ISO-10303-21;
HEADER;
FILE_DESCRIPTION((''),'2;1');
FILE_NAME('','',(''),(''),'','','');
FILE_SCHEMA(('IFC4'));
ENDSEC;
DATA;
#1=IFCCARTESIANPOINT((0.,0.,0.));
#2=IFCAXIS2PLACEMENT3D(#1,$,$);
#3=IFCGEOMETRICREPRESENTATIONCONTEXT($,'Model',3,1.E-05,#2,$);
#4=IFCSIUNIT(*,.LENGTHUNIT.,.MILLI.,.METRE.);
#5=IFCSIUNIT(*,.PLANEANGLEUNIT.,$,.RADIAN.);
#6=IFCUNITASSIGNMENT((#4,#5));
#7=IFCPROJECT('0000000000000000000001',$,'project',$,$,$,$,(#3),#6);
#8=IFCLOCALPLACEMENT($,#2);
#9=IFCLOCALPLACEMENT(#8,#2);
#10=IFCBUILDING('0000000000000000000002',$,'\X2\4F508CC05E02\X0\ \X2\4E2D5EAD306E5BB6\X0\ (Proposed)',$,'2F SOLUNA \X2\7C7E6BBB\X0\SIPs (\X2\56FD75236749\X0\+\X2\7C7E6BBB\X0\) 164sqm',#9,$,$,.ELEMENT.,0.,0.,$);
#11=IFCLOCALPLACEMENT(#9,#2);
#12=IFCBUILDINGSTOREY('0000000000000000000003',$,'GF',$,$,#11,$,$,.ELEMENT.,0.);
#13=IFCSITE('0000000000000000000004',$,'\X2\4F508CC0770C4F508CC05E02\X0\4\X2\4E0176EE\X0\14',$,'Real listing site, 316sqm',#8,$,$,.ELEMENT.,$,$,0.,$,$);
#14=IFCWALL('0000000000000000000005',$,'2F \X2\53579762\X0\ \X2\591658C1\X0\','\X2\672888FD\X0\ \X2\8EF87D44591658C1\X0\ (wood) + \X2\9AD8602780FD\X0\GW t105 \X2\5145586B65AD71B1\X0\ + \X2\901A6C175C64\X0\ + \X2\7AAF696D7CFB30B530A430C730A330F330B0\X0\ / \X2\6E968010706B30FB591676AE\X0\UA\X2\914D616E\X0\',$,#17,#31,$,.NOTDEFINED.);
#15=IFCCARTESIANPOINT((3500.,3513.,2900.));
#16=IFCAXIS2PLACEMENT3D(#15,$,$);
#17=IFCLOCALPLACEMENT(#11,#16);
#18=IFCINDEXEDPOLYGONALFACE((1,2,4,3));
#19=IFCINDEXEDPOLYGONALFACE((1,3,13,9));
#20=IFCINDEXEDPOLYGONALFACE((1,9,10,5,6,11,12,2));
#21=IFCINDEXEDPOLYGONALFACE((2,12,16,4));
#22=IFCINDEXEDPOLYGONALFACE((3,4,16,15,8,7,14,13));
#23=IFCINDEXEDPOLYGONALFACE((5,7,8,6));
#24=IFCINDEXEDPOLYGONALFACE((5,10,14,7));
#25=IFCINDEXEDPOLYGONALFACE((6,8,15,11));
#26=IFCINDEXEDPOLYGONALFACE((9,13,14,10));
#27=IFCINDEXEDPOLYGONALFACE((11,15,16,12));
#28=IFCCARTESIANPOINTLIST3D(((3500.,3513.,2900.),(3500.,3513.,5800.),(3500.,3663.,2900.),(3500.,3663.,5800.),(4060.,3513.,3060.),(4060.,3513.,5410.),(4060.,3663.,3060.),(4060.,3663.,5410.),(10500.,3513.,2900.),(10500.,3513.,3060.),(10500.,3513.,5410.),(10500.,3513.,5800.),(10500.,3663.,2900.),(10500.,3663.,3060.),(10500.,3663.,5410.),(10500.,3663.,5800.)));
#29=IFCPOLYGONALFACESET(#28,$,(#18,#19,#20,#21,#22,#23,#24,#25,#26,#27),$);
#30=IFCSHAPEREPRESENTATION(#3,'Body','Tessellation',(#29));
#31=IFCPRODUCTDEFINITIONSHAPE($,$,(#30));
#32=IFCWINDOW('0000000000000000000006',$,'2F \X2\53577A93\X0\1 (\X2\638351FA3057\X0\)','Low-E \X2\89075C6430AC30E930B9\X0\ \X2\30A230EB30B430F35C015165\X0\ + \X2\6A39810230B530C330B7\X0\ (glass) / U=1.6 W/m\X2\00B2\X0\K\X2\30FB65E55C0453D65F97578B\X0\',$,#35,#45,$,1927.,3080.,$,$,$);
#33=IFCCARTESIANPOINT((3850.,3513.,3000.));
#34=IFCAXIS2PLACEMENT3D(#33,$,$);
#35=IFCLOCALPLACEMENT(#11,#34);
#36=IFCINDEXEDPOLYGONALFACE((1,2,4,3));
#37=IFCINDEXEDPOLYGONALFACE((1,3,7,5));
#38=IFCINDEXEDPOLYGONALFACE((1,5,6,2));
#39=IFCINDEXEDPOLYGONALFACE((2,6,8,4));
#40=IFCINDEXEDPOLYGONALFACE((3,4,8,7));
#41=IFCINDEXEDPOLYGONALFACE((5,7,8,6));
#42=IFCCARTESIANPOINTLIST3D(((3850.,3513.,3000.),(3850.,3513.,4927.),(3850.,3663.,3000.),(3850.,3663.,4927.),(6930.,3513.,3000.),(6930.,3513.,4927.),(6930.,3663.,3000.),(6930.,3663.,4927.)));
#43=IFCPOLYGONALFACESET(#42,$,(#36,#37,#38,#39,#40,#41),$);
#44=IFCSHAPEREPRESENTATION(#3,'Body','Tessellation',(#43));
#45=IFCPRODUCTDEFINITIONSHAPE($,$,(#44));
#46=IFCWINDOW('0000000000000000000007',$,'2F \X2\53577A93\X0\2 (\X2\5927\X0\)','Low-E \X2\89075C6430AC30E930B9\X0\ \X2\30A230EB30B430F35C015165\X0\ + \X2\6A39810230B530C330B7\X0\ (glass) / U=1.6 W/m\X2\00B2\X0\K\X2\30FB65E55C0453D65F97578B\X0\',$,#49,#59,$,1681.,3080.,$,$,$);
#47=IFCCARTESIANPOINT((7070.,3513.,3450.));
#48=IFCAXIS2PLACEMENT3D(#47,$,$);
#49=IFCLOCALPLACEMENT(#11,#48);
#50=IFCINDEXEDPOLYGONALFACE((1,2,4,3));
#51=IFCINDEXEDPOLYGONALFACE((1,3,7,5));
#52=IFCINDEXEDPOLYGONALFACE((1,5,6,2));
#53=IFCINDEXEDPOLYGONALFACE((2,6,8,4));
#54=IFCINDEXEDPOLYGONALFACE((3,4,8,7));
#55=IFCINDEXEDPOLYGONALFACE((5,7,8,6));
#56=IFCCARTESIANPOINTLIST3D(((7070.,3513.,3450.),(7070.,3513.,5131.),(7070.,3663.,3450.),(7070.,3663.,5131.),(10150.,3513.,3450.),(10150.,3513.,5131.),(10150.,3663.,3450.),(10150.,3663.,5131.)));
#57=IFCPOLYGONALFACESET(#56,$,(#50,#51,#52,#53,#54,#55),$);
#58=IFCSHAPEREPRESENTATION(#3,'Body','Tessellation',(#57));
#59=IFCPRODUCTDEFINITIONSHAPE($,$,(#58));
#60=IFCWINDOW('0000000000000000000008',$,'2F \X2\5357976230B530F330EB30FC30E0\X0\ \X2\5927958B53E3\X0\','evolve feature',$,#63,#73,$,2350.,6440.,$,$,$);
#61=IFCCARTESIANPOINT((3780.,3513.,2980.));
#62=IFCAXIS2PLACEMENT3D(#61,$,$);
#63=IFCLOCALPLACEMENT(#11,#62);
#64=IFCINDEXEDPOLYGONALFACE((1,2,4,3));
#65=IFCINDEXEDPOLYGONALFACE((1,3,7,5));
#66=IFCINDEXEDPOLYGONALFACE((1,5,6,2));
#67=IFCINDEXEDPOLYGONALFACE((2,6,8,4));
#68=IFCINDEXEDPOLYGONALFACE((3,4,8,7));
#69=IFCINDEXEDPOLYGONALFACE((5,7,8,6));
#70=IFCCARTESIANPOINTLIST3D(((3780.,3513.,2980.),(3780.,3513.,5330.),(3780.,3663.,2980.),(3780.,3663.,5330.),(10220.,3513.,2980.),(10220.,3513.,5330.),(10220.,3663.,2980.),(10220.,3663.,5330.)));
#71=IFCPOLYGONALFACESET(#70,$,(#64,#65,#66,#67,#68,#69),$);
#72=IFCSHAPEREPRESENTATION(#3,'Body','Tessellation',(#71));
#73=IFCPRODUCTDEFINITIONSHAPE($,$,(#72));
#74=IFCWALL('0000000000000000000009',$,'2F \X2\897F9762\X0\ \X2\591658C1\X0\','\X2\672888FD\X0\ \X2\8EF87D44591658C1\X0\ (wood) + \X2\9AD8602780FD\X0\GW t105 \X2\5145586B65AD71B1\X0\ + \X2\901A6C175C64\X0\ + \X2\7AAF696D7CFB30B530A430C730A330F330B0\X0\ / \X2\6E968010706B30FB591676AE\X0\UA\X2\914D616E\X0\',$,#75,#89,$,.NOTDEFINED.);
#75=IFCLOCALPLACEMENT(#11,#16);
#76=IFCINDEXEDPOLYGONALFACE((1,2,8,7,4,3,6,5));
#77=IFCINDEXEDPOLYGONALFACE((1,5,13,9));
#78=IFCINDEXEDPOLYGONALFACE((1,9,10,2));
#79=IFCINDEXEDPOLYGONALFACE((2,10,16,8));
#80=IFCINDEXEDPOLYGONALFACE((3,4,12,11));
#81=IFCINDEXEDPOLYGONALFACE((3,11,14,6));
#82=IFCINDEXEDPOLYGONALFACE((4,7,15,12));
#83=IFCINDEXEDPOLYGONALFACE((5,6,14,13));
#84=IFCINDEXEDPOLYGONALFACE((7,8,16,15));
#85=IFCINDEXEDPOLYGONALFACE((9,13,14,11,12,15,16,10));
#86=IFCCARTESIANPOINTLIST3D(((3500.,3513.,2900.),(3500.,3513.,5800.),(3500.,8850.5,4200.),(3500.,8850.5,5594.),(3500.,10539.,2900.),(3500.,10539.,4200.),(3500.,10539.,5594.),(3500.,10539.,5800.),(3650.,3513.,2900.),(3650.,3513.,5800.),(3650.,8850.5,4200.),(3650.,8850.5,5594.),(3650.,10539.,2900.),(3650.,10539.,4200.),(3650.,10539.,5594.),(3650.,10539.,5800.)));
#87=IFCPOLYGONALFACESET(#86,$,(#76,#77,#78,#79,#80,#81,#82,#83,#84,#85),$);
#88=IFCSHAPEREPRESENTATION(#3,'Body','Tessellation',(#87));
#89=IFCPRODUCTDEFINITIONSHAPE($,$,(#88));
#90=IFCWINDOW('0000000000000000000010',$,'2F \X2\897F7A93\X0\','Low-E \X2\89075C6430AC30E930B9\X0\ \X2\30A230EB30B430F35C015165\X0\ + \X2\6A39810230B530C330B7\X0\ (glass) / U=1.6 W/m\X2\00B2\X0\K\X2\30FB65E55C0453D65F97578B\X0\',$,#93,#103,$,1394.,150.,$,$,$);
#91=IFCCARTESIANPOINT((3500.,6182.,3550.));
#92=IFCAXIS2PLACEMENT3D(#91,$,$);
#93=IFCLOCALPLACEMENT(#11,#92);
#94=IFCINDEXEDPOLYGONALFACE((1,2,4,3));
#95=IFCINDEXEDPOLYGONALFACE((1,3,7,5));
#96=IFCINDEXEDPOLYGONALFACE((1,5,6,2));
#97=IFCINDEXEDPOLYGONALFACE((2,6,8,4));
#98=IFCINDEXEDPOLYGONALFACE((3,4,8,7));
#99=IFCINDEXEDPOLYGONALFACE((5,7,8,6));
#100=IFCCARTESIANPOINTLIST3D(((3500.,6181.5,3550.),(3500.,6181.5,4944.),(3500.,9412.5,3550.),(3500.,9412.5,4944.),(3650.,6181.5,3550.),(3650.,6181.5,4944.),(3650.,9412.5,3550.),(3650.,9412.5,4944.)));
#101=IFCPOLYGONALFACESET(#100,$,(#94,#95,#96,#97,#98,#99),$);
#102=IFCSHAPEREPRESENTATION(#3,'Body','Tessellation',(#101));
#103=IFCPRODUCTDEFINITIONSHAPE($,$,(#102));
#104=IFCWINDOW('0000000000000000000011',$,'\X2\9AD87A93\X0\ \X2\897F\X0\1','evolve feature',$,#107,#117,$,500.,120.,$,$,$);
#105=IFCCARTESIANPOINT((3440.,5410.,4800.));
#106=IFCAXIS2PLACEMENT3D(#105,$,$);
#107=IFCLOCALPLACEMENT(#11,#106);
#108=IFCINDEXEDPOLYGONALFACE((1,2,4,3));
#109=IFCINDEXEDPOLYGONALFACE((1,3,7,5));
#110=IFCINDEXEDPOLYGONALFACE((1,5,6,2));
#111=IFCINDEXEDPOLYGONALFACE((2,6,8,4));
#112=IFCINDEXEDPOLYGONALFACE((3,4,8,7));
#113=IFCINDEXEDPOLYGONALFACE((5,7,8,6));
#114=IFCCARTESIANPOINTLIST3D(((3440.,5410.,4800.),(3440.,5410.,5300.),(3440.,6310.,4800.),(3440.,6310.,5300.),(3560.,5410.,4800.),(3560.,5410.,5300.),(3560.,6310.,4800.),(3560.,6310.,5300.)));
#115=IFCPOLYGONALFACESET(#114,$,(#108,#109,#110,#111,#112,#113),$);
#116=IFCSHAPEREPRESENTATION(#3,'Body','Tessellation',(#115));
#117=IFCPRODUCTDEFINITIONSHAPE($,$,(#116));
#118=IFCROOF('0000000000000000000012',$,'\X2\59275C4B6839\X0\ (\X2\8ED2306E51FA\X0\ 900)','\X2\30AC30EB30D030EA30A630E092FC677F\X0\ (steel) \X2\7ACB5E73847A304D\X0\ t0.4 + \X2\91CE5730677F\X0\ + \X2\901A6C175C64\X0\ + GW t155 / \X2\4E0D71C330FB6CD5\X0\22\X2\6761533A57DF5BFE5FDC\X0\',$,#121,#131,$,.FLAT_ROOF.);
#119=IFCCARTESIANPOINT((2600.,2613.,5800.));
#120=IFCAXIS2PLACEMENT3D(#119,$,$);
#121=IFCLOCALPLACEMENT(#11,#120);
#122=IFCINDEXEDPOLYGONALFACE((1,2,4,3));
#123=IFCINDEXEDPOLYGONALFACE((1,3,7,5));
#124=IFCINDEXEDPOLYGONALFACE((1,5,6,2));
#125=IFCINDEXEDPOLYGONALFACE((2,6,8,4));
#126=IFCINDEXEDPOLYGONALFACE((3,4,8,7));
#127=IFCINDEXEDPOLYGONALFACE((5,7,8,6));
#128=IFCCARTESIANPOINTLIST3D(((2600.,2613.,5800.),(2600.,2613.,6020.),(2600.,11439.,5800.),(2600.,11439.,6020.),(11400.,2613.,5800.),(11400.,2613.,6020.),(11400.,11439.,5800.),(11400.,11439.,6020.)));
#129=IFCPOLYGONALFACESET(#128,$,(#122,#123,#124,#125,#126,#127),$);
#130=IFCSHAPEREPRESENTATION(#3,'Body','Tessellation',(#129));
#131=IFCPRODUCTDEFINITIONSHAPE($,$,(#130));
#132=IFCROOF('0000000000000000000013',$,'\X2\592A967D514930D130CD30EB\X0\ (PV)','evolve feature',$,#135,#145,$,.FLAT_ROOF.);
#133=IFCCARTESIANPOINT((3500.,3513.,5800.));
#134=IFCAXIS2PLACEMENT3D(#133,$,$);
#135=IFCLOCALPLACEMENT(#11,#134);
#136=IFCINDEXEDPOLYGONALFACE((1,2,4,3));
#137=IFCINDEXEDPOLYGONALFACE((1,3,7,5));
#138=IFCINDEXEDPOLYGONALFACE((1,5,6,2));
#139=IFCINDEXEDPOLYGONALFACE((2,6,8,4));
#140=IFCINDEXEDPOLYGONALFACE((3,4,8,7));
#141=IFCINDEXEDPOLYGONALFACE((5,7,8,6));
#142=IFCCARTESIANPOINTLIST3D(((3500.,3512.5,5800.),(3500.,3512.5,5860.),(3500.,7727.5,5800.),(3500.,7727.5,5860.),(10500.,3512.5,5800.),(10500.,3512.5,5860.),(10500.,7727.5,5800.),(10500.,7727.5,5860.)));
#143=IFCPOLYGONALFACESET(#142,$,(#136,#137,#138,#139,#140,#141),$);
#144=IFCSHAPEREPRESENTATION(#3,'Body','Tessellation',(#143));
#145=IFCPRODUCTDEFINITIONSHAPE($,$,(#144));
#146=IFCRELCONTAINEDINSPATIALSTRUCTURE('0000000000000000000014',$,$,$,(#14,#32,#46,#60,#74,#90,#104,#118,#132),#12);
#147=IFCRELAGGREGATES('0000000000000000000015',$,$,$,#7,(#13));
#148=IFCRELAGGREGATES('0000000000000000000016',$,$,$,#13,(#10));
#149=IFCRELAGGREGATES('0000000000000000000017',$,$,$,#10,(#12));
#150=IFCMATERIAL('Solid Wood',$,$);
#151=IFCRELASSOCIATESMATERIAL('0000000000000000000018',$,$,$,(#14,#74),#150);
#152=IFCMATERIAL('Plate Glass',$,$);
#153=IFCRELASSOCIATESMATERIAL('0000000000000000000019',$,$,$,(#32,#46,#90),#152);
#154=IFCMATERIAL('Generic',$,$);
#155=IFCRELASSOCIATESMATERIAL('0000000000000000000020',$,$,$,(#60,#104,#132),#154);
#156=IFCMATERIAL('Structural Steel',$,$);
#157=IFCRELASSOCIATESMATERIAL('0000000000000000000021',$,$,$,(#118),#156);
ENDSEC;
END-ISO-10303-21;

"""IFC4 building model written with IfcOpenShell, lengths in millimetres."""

from ifc_helpers import new_model, si_unit, frame, frame_2d, origin, place, context, project, spatial, rectangle, extrude, material, element, fill, save


model = new_model("IFC4")

# Units and contexts
model_context = context("Model", 3, precision=1e-05, world=origin())
ifc_project = project(units=[si_unit("LENGTHUNIT", "METRE", prefix="MILLI"), si_unit("PLANEANGLEUNIT", "RADIAN")], contexts=[model_context])

# Site, building, storey
site_placement = place(None, origin())
site = spatial("IfcSite", under=ifc_project, at=site_placement, Name="佐賀県佐賀市4丁目14", ObjectType="Real listing site, 316sqm", CompositionType="ELEMENT", RefElevation=0.0)
building_placement = place(site_placement, origin())
building = spatial("IfcBuilding", under=site, at=building_placement, Name="佐賀市 中庭の家 (Proposed)", ObjectType="2F SOLUNA 籾殻SIPs (国産杉+籾殻) 164sqm", CompositionType="ELEMENT", ElevationOfRefHeight=0.0, ElevationOfTerrain=0.0)
storey_placement = place(building_placement, origin())
storey = spatial("IfcBuildingStorey", under=building, at=storey_placement, Name="GF", CompositionType="ELEMENT", Elevation=0.0)

# Shared definitions
ifc_material_1 = material(Name="Solid Wood")
ifc_material_2 = material(Name="Generic")

# Shared definitions
ifc_material_3 = material(Name="Plate Glass")

# Walls, openings, windows
wall_1_placement = place(storey_placement, frame((3500.0, 3513.0, 2900.0)))
wall_1 = element("IfcWall", 1, at=wall_1_placement, inside=storey, material=ifc_material_1, Name="2F 南面 外壁", Description="木製 軸組外壁 (wood) + 高性能GW t105 充填断熱 + 通気層 + 窯業系サイディング / 準耐火・外皮UA配慮", PredefinedType="NOTDEFINED", context=model_context, shape_type="SweptSolid", body=[
    extrude(rectangle(XDim=7000.0, YDim=150.0, at=frame_2d((3500.0, 75.0))), frame((3500.0, 3513.0, 2900.0)), (0.0, 0.0, 1.0), 2900.0),
])
opening_1_placement = place(storey_placement, frame((3850.0, 3513.0, 3000.0)))
opening_1 = element("IfcOpeningElement", 2, at=opening_1_placement, cuts=wall_1, PredefinedType="NOTDEFINED", context=model_context, shape_type="SweptSolid", body=[
    extrude(rectangle(XDim=3080.0, YDim=150.0, at=frame_2d((1540.0, 75.0))), frame((3850.0, 3513.0, 3000.0)), (0.0, 0.0, 1.0), 1927.0),
])
opening_2_placement = place(storey_placement, frame((7070.0, 3513.0, 3450.0)))
opening_2 = element("IfcOpeningElement", 3, at=opening_2_placement, cuts=wall_1, PredefinedType="NOTDEFINED", context=model_context, shape_type="SweptSolid", body=[
    extrude(rectangle(XDim=3080.0, YDim=150.0, at=frame_2d((1540.0, 75.0))), frame((7070.0, 3513.0, 3450.0)), (0.0, 0.0, 1.0), 1681.0),
])
opening_3_placement = place(storey_placement, frame((3780.0, 3513.0, 2980.0)))
opening_3 = element("IfcOpeningElement", 4, at=opening_3_placement, cuts=wall_1, PredefinedType="NOTDEFINED", context=model_context, shape_type="SweptSolid", body=[
    extrude(rectangle(XDim=6440.0, YDim=150.0, at=frame_2d((3220.0, 75.0))), frame((3780.0, 3513.0, 2980.0)), (0.0, 0.0, 1.0), 2350.0),
])
window_1_placement = place(storey_placement, frame((3850.0, 3513.0, 3000.0)))
window_1 = element("IfcWindow", 5, at=window_1_placement, inside=storey, material=ifc_material_3, Name="2F 南窓1 (掃出し)", Description="Low-E 複層ガラス アルゴン封入 + 樹脂サッシ (glass) / U=1.6 W/m²K・日射取得型", OverallHeight=1927.0, OverallWidth=3080.0, context=model_context, shape_type="SweptSolid", body=[
    extrude(rectangle(XDim=3080.0, YDim=150.0, at=frame_2d((1540.0, 75.0))), frame((3850.0, 3513.0, 3000.0)), (0.0, 0.0, 1.0), 1927.0),
])
fill(opening_1, window_1)
window_2_placement = place(storey_placement, frame((7070.0, 3513.0, 3450.0)))
window_2 = element("IfcWindow", 6, at=window_2_placement, inside=storey, material=ifc_material_3, Name="2F 南窓2 (大)", Description="Low-E 複層ガラス アルゴン封入 + 樹脂サッシ (glass) / U=1.6 W/m²K・日射取得型", OverallHeight=1681.0, OverallWidth=3080.0, context=model_context, shape_type="SweptSolid", body=[
    extrude(rectangle(XDim=3080.0, YDim=150.0, at=frame_2d((1540.0, 75.0))), frame((7070.0, 3513.0, 3450.0)), (0.0, 0.0, 1.0), 1681.0),
])
fill(opening_2, window_2)
window_3_placement = place(storey_placement, frame((3780.0, 3513.0, 2980.0)))
window_3 = element("IfcWindow", 7, at=window_3_placement, inside=storey, material=ifc_material_2, Name="2F 南面サンルーム 大開口", Description="evolve feature", OverallHeight=2350.0, OverallWidth=6440.0, context=model_context, shape_type="SweptSolid", body=[
    extrude(rectangle(XDim=6440.0, YDim=150.0, at=frame_2d((3220.0, 75.0))), frame((3780.0, 3513.0, 2980.0)), (0.0, 0.0, 1.0), 2350.0),
])
fill(opening_3, window_3)
wall_2_placement = place(storey_placement, frame((3500.0, 3513.0, 2900.0)))
wall_2 = element("IfcWall", 8, at=wall_2_placement, inside=storey, material=ifc_material_1, Name="2F 西面 外壁", Description="木製 軸組外壁 (wood) + 高性能GW t105 充填断熱 + 通気層 + 窯業系サイディング / 準耐火・外皮UA配慮", PredefinedType="NOTDEFINED", context=model_context, shape_type="SweptSolid", body=[
    extrude(rectangle(XDim=150.0, YDim=7026.0, at=frame_2d((75.0, 3513.0))), frame((3500.0, 3513.0, 2900.0)), (0.0, 0.0, 1.0), 2900.0),
])
opening_4_placement = place(storey_placement, frame((3500.0, 6182.0, 3550.0)))
opening_4 = element("IfcOpeningElement", 9, at=opening_4_placement, cuts=wall_2, PredefinedType="NOTDEFINED", context=model_context, shape_type="SweptSolid", body=[
    extrude(rectangle(XDim=150.0, YDim=3231.0, at=frame_2d((75.0, 1615.0))), frame((3500.0, 6182.0, 3550.0)), (0.0, 0.0, 1.0), 1394.0),
])
opening_5_placement = place(storey_placement, frame((3440.0, 5410.0, 4800.0)))
opening_5 = element("IfcOpeningElement", 10, at=opening_5_placement, cuts=wall_2, PredefinedType="NOTDEFINED", context=model_context, shape_type="SweptSolid", body=[
    extrude(rectangle(XDim=120.0, YDim=900.0, at=frame_2d((60.0, 450.0))), frame((3440.0, 5410.0, 4800.0)), (0.0, 0.0, 1.0), 500.0),
])
window_4_placement = place(storey_placement, frame((3500.0, 6182.0, 3550.0)))
window_4 = element("IfcWindow", 11, at=window_4_placement, inside=storey, material=ifc_material_3, Name="2F 西窓", Description="Low-E 複層ガラス アルゴン封入 + 樹脂サッシ (glass) / U=1.6 W/m²K・日射取得型", OverallHeight=1394.0, OverallWidth=150.0, context=model_context, shape_type="SweptSolid", body=[
    extrude(rectangle(XDim=150.0, YDim=3231.0, at=frame_2d((75.0, 1615.0))), frame((3500.0, 6182.0, 3550.0)), (0.0, 0.0, 1.0), 1394.0),
])
fill(opening_4, window_4)
window_5_placement = place(storey_placement, frame((3440.0, 5410.0, 4800.0)))
window_5 = element("IfcWindow", 12, at=window_5_placement, inside=storey, material=ifc_material_2, Name="高窓 西1", Description="evolve feature", OverallHeight=500.0, OverallWidth=120.0, context=model_context, shape_type="SweptSolid", body=[
    extrude(rectangle(XDim=120.0, YDim=900.0, at=frame_2d((60.0, 450.0))), frame((3440.0, 5410.0, 4800.0)), (0.0, 0.0, 1.0), 500.0),
])
fill(opening_5, window_5)

# Roofs
ifc_material_4 = material(Name="Structural Steel")
roof_1_placement = place(storey_placement, frame((2600.0, 2613.0, 5800.0)))
element("IfcRoof", 13, at=roof_1_placement, inside=storey, material=ifc_material_4, Name="大屋根 (軒の出 900)", Description="ガルバリウム鋼板 (steel) 立平葺き t0.4 + 野地板 + 通気層 + GW t155 / 不燃・法22条区域対応", PredefinedType="FLAT_ROOF", context=model_context, shape_type="SweptSolid", body=[
    extrude(rectangle(XDim=8800.0, YDim=8826.0, at=frame_2d((4400.0, 4413.0))), frame((2600.0, 2613.0, 5800.0)), (0.0, 0.0, 1.0), 220.0),
])
roof_2_placement = place(storey_placement, frame((3500.0, 3513.0, 5800.0)))
element("IfcRoof", 14, at=roof_2_placement, inside=storey, material=ifc_material_2, Name="太陽光パネル (PV)", Description="evolve feature", PredefinedType="FLAT_ROOF", context=model_context, shape_type="SweptSolid", body=[
    extrude(rectangle(XDim=7000.0, YDim=4215.0, at=frame_2d((3500.0, 2107.0))), frame((3500.0, 3513.0, 5800.0)), (0.0, 0.0, 1.0), 60.0),
])

save(model, "model.ifc")
